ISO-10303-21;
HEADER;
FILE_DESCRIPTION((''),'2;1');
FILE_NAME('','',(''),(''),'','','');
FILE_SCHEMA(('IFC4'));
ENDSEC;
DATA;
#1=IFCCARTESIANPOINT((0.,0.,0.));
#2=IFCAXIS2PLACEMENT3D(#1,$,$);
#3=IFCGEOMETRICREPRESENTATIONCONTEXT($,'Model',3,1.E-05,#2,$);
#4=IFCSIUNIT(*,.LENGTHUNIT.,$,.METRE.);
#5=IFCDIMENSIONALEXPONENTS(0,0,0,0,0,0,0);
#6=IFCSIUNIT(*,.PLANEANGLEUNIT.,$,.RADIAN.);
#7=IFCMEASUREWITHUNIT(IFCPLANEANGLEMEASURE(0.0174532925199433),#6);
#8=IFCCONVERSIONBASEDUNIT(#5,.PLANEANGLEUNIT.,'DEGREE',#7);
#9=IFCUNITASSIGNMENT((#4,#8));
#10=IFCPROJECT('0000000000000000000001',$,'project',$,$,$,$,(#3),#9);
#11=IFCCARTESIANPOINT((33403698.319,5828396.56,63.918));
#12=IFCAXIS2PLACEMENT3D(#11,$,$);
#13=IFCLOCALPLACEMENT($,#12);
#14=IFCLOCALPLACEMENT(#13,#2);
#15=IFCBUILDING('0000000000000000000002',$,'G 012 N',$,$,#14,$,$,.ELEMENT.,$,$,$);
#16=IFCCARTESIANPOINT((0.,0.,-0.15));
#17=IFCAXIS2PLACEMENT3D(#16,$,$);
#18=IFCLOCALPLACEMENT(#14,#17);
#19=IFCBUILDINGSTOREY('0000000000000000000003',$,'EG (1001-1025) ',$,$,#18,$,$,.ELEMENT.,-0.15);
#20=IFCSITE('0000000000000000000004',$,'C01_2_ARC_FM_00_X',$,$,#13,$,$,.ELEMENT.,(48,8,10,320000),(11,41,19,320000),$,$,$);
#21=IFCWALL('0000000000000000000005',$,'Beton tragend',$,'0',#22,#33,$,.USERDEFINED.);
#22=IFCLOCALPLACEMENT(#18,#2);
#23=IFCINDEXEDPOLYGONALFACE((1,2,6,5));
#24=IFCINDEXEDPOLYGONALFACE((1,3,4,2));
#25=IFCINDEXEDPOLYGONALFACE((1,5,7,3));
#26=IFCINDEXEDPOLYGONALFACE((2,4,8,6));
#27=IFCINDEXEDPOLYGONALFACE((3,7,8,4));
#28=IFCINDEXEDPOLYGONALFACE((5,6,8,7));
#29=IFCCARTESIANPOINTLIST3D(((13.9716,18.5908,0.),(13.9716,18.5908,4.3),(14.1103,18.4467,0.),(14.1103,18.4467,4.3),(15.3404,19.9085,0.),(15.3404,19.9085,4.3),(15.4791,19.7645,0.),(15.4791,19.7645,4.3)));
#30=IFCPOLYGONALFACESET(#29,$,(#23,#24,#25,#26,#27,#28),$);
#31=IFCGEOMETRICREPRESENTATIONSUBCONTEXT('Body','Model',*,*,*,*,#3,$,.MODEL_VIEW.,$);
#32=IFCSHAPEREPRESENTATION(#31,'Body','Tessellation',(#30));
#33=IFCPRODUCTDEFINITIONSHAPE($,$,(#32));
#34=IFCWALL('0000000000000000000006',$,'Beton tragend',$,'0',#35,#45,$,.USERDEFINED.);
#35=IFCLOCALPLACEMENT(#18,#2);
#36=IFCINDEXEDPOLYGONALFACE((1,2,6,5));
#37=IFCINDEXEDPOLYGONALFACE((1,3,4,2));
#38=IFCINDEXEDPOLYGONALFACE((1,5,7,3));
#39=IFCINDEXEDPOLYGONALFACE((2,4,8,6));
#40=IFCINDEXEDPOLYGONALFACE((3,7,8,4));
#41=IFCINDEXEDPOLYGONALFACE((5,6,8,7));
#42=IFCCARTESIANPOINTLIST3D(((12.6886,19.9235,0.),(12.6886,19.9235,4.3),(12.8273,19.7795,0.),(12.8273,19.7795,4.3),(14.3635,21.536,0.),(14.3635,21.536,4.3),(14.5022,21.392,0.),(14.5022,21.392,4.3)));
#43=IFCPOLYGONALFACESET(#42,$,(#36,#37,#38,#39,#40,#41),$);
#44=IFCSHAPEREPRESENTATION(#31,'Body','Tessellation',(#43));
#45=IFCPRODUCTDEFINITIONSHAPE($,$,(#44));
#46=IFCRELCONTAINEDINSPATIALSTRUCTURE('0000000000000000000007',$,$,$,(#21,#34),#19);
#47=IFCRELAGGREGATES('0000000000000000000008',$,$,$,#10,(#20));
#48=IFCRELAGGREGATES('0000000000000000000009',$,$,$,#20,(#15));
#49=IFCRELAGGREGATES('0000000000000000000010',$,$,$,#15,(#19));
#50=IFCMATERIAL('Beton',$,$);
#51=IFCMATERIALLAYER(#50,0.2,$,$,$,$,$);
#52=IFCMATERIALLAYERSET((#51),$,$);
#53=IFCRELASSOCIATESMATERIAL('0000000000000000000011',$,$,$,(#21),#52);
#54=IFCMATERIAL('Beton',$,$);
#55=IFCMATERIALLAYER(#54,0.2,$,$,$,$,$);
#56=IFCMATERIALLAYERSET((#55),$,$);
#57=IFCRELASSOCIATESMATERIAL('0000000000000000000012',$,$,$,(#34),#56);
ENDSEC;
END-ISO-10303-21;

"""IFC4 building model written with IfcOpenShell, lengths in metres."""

from ifc_helpers import new_model, entity, si_unit, converted_unit, frame, frame_2d, origin, origin_with_axes, place, context, subcontext, project, spatial, rectangle, extrude, material, layer, layer_set, layer_usage, element, save


model = new_model("IFC4")

# Units and contexts
model_context = context("Model", 3, precision=1e-05, world=origin())
body_context = subcontext(model_context, "Body", "Model", "MODEL_VIEW")
ifc_project = project(units=[si_unit("LENGTHUNIT", "METRE"), converted_unit("PLANEANGLEUNIT", "DEGREE", entity("IfcPlaneAngleMeasure", 0.0174532925199433), si_unit("PLANEANGLEUNIT", "RADIAN"), dimensions=[0, 0, 0, 0, 0, 0, 0])], contexts=[model_context])

# Site, building, storey
site_placement = place(None, frame((33403698.319, 5828396.56, 63.918)))
site = spatial("IfcSite", under=ifc_project, at=site_placement, Name="C01_2_ARC_FM_00_X", CompositionType="ELEMENT", RefLatitude=(48, 8, 10, 320000), RefLongitude=(11, 41, 19, 320000))
building_placement = place(site_placement, origin())
building = spatial("IfcBuilding", under=site, at=building_placement, Name="G 012 N", CompositionType="ELEMENT")
storey_placement = place(building_placement, frame((0.0, 0.0, -0.15)))
storey = spatial("IfcBuildingStorey", under=building, at=storey_placement, Name="EG (1001-1025) ", CompositionType="ELEMENT", Elevation=-0.15)

# Walls
ifc_material_1 = material(Name="Beton")
ifc_layer_1 = layer(ifc_material_1, 0.2)
ifc_layer_set_1 = layer_set([ifc_layer_1])
ifc_layer_usage_1 = layer_usage(ifc_layer_set_1, "AXIS2", "POSITIVE", 0.0)
wall_1_placement = place(storey_placement, frame((15.3404, 19.9085, 0.0), z_axis=(0.0, 0.0, 1.0), x_axis=(-0.720408, -0.693551, 0.0)))
element("IfcWall", 1, at=wall_1_placement, inside=storey, material=ifc_layer_usage_1, Name="Beton tragend", ObjectType="0", PredefinedType="USERDEFINED", context=body_context, shape_type="SweptSolid", body=[
    extrude(rectangle(XDim=1.9, YDim=0.2, at=frame_2d((0.95, 0.1), x_axis=(1.0, 0.0))), origin_with_axes(), (0.0, 0.0, 1.0), 4.3),
])
ifc_material_2 = material(Name="Beton")
ifc_layer_2 = layer(ifc_material_2, 0.2)
ifc_layer_set_2 = layer_set([ifc_layer_2])
ifc_layer_usage_2 = layer_usage(ifc_layer_set_2, "AXIS2", "POSITIVE", 0.0)
wall_2_placement = place(storey_placement, frame((14.3635, 21.536, 0.0), z_axis=(0.0, 0.0, 1.0), x_axis=(-0.720408, -0.693551, 0.0)))
element("IfcWall", 2, at=wall_2_placement, inside=storey, material=ifc_layer_usage_2, Name="Beton tragend", ObjectType="0", PredefinedType="USERDEFINED", context=body_context, shape_type="SweptSolid", body=[
    extrude(rectangle(XDim=2.325, YDim=0.2, at=frame_2d((1.1625, 0.1), x_axis=(1.0, 0.0))), origin_with_axes(), (0.0, 0.0, 1.0), 4.3),
])

save(model, "model.ifc")
